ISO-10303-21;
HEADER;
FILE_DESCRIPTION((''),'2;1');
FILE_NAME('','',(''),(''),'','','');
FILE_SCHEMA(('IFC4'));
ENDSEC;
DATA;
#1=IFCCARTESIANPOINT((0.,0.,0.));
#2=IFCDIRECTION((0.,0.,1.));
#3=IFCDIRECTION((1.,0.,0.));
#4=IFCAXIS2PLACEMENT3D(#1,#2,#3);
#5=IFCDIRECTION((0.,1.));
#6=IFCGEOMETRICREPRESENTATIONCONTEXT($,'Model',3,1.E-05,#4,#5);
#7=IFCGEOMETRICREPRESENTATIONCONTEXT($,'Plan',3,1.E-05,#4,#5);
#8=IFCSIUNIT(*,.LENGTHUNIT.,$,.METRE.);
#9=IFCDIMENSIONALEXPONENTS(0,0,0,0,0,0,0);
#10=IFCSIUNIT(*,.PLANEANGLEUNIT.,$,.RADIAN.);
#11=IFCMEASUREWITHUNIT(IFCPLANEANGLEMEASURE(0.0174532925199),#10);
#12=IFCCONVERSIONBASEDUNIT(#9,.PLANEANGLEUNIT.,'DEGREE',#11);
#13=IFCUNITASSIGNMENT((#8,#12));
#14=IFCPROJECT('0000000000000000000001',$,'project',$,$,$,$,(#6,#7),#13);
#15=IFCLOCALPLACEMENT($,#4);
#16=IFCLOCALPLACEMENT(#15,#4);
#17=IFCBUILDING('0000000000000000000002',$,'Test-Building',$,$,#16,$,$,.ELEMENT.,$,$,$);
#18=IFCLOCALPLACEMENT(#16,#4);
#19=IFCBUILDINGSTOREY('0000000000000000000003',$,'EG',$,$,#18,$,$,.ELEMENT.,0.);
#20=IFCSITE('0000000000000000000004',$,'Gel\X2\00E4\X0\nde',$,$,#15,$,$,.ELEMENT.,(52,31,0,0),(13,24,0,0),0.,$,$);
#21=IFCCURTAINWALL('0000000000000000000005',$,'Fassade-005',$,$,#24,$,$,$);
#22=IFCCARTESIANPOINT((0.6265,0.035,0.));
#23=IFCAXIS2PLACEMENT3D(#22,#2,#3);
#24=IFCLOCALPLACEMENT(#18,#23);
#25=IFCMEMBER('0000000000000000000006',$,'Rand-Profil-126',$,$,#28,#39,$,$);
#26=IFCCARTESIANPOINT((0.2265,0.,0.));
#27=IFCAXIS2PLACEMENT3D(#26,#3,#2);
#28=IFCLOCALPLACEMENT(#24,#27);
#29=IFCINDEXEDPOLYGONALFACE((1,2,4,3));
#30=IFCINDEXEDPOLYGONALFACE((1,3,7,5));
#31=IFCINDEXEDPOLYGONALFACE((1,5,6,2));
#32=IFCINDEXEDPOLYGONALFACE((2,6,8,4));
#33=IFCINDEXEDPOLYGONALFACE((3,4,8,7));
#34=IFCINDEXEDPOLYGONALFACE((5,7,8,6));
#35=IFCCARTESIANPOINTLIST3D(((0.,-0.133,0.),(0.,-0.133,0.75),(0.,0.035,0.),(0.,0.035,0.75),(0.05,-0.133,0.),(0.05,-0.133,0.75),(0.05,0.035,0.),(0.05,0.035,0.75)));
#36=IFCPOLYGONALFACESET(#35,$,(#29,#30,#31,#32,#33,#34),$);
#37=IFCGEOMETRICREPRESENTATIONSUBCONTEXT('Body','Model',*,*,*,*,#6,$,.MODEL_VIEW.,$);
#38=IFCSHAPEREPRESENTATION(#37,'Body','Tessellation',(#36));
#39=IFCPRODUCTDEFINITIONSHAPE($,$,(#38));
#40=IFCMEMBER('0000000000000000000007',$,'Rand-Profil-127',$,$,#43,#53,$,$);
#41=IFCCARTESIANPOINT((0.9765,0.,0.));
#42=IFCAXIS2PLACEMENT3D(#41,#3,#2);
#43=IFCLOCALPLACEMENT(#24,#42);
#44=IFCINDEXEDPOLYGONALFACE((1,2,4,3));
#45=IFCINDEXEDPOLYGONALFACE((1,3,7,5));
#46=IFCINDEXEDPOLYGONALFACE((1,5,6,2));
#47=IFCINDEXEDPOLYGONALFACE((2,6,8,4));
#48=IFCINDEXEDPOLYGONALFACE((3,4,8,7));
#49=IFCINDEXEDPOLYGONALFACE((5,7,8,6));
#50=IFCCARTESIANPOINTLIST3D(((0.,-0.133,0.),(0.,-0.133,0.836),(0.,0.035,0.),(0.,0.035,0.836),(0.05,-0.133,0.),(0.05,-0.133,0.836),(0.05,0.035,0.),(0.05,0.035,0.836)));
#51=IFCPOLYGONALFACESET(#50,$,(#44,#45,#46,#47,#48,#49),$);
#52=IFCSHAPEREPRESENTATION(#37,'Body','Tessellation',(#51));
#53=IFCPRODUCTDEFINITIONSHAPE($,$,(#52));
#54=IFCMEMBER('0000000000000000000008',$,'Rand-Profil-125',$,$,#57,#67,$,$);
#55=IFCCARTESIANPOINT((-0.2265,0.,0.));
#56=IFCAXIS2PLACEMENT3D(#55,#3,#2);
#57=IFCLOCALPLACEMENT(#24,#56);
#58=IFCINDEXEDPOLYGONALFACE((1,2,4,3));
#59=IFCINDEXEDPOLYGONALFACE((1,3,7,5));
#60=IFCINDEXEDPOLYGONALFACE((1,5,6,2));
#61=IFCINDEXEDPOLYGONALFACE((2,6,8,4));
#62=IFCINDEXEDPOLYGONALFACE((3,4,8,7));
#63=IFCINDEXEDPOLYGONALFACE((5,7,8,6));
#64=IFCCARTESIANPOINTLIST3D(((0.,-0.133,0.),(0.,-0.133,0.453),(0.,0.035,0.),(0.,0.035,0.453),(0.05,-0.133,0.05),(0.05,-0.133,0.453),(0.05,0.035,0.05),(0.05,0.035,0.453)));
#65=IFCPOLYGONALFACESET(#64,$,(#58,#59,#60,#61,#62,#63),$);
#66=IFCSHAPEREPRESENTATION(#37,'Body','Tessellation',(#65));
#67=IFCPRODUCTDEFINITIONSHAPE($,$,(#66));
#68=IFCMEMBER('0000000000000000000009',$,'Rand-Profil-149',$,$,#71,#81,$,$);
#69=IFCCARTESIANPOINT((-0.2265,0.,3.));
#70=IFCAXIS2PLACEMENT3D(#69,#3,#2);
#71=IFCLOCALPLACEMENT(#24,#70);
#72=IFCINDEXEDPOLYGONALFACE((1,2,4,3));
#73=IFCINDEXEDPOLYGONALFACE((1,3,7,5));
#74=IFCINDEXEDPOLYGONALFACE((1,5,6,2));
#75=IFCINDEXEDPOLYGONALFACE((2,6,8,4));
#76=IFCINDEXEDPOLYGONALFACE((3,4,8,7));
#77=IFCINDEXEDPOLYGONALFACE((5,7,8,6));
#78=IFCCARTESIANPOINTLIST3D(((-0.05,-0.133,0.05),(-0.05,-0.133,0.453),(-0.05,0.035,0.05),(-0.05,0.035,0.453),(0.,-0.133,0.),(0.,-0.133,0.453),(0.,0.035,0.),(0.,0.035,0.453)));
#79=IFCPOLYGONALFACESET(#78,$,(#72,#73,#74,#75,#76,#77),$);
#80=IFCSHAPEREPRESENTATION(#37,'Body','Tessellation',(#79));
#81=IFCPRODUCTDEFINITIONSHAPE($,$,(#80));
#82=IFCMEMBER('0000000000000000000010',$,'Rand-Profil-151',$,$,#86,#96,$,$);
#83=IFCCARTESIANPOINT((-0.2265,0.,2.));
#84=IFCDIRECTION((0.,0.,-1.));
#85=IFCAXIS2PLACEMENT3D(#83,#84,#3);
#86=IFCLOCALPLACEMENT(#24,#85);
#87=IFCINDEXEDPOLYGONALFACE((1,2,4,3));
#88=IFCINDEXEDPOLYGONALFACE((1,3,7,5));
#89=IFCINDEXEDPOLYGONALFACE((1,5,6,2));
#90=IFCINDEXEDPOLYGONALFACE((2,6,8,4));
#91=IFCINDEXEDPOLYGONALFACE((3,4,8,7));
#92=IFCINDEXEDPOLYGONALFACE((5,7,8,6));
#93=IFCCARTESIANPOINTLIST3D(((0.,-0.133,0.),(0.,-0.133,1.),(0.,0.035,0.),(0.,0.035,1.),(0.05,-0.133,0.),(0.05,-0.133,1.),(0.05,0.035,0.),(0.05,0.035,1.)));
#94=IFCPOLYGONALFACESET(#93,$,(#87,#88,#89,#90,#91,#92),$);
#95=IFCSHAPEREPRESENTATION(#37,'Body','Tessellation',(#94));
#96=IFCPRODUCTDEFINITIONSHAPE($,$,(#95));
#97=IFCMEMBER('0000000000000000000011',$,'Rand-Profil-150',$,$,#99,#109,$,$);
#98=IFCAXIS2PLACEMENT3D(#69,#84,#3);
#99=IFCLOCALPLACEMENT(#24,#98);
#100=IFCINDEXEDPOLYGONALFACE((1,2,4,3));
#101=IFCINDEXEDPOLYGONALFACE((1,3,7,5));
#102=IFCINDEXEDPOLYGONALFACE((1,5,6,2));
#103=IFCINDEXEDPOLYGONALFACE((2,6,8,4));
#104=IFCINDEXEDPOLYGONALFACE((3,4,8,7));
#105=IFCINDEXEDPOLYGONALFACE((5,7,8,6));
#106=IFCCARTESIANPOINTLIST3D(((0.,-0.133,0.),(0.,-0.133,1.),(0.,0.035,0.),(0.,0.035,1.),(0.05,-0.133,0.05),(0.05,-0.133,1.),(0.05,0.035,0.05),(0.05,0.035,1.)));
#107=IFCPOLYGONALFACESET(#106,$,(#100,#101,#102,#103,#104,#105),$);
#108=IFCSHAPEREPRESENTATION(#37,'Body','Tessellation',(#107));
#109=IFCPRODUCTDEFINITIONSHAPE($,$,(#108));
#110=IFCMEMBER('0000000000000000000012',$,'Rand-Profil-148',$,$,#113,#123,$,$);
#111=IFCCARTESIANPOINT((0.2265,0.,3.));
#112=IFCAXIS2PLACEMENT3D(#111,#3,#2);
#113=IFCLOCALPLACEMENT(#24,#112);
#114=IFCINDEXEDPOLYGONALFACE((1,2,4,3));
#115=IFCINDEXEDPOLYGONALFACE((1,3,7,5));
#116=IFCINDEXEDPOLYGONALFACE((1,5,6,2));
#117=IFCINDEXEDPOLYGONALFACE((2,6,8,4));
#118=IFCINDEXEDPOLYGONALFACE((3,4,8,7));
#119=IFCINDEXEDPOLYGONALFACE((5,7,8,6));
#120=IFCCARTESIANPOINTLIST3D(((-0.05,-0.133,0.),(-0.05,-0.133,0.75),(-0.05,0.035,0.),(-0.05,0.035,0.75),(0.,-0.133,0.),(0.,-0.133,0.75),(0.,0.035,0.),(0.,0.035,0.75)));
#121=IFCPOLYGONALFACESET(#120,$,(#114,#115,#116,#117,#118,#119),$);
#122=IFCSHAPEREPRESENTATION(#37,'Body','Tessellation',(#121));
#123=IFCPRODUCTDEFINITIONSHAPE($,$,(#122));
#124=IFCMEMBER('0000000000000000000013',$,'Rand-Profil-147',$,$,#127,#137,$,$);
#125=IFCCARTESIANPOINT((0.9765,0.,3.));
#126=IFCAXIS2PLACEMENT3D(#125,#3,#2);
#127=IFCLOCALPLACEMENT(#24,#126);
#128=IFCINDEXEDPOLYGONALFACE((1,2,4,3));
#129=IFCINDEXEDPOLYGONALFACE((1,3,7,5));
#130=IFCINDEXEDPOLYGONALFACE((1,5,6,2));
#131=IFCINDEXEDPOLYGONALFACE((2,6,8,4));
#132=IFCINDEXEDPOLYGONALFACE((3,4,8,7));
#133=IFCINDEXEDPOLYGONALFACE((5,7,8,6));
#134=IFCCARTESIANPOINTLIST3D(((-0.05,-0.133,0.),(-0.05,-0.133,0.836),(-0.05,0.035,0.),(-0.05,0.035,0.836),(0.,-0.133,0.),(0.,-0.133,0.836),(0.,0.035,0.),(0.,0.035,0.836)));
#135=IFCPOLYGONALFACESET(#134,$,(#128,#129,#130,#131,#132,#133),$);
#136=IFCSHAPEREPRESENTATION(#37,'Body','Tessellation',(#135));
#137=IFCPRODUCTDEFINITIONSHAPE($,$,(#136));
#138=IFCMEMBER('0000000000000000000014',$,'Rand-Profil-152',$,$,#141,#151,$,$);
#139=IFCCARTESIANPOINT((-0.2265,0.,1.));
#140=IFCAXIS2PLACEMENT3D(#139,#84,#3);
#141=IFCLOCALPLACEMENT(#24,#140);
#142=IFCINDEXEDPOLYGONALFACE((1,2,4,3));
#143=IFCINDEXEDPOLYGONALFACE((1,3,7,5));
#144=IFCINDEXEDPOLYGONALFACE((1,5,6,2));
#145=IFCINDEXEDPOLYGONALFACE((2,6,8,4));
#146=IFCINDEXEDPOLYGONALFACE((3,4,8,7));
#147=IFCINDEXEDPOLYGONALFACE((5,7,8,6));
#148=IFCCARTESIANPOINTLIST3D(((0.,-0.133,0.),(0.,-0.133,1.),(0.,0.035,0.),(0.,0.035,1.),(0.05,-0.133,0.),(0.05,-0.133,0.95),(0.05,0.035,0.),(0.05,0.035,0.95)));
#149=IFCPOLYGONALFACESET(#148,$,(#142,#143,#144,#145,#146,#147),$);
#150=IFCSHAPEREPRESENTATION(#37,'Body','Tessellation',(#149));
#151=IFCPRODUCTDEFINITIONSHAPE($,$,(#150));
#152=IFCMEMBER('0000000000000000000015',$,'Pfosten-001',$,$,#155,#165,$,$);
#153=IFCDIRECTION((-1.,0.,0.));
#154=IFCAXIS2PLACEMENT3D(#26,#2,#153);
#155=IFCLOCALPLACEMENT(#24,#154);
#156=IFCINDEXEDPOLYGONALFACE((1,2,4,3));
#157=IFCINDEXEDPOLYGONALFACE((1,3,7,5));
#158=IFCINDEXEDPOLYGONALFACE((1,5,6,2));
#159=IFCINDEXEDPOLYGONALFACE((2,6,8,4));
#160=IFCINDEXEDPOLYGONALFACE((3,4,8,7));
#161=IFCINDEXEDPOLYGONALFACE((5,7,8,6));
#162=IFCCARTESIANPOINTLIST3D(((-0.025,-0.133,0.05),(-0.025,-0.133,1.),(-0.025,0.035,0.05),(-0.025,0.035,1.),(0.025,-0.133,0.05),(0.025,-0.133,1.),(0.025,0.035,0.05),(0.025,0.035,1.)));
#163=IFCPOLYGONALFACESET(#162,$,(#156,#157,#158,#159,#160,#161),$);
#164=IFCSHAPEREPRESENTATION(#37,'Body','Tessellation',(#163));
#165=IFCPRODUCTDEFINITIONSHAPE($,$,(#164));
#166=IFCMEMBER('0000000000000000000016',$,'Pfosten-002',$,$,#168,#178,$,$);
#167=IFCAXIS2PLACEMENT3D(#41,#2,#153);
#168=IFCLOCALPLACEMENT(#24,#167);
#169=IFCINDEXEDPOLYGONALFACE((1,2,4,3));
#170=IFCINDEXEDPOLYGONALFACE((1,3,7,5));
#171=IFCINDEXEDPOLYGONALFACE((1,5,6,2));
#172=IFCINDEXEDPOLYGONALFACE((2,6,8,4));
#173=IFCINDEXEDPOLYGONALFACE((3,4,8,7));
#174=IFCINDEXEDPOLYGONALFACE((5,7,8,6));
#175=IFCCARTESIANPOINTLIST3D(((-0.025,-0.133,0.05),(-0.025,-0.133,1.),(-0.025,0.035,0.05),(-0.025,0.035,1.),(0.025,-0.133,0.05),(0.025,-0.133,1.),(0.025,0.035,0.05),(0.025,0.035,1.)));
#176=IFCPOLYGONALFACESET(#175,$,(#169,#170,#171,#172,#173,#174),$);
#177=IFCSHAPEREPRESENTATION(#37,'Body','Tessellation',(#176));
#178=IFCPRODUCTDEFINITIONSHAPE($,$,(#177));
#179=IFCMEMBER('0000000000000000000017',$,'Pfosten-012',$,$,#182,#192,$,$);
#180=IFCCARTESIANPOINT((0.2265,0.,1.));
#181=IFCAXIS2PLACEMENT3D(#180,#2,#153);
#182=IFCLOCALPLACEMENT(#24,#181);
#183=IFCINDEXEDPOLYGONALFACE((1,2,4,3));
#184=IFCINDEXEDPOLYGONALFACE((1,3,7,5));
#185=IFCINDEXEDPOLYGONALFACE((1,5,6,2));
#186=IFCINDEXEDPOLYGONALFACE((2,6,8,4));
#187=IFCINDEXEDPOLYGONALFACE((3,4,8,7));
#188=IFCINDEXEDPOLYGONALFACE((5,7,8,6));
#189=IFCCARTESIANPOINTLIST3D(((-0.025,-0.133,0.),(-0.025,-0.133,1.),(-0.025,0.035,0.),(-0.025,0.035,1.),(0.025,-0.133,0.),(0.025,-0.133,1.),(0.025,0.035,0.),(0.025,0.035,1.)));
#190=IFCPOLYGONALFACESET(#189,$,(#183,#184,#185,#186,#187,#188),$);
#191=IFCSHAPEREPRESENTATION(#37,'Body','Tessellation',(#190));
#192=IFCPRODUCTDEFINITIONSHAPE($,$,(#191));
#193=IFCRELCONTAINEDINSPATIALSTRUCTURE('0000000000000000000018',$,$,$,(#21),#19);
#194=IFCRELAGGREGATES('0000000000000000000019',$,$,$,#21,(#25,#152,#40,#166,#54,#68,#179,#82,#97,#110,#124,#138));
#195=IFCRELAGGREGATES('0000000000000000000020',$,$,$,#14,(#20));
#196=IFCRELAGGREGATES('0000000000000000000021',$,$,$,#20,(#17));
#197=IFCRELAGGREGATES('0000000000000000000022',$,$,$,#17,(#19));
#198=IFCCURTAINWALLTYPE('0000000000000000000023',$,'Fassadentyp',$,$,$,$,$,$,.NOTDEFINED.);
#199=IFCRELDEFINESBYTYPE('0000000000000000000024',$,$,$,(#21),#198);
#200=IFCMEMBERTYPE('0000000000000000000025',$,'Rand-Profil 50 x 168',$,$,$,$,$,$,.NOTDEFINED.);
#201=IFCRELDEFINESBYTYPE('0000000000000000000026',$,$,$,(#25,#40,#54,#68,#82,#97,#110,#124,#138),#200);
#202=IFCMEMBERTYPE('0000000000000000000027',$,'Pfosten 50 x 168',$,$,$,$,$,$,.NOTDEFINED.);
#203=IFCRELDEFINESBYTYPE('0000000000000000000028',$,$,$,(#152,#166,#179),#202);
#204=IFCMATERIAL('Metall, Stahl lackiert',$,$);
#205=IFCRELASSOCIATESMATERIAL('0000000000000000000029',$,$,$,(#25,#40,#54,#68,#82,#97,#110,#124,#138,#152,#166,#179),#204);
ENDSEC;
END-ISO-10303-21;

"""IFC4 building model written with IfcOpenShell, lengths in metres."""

from ifc_helpers import new_model, entity, si_unit, converted_unit, direction, frame, origin_with_axes, place, context, subcontext, project, spatial, polyline, outline, extrude, clip, halfspace, material, type_object, element, aggregate, save


model = new_model("IFC4")

# Units and contexts
model_context = context("Model", 3, precision=1e-05, world=origin_with_axes(), true_north=direction((0.0, 1.0)))
plan_context = context("Plan", 3, precision=1e-05, world=origin_with_axes(), true_north=direction((0.0, 1.0)))
body_context = subcontext(model_context, "Body", "Model", "MODEL_VIEW")
ifc_project = project(units=[si_unit("LENGTHUNIT", "METRE"), converted_unit("PLANEANGLEUNIT", "DEGREE", entity("IfcPlaneAngleMeasure", 0.0174532925199), si_unit("PLANEANGLEUNIT", "RADIAN"), dimensions=[0, 0, 0, 0, 0, 0, 0])], contexts=[model_context, plan_context])

# Site, building, storey
site_placement = place(None, origin_with_axes())
site = spatial("IfcSite", under=ifc_project, at=site_placement, Name="Gelände", CompositionType="ELEMENT", RefLatitude=(52, 31, 0, 0), RefLongitude=(13, 24, 0, 0), RefElevation=0.0)
building_placement = place(site_placement, origin_with_axes())
building = spatial("IfcBuilding", under=site, at=building_placement, Name="Test-Building", CompositionType="ELEMENT")
storey_placement = place(building_placement, origin_with_axes())
storey = spatial("IfcBuildingStorey", under=building, at=storey_placement, Name="EG", CompositionType="ELEMENT", Elevation=0.0)

# Curtain wall, members
curtain_wall_type = type_object("IfcCurtainWallType", Name="Fassadentyp", PredefinedType="NOTDEFINED")
curtain_wall_placement = place(storey_placement, frame((0.6265, 0.035, 0.0), z_axis=(0.0, 0.0, 1.0), x_axis=(1.0, 0.0, 0.0)))
curtain_wall = element("IfcCurtainWall", 1, at=curtain_wall_placement, inside=storey, type_object=curtain_wall_type, Name="Fassade-005")
ifc_material_1 = material(Name="Metall, Stahl lackiert")
member_type_1 = type_object("IfcMemberType", Name="Rand-Profil 50 x 168", PredefinedType="NOTDEFINED")
member_1_placement = place(curtain_wall_placement, frame((0.2265, 0.0, 0.0), z_axis=(1.0, 0.0, 0.0), x_axis=(0.0, 0.0, 1.0)))
member_1 = element("IfcMember", 2, at=member_1_placement, type_object=member_type_1, material=ifc_material_1, Name="Rand-Profil-126", context=body_context, shape_type="SweptSolid", body=[
    extrude(outline(polyline([(-0.133, -0.05), (0.035, -0.05), (0.035, 0.0), (-0.133, 0.0), (-0.133, -0.05)])), frame((0.0, 0.0, 0.0), z_axis=(0.0, 0.0, 1.0), x_axis=(0.0, 1.0, 0.0)), (0.0, 0.0, 1.0), 0.75),
])
member_2_placement = place(curtain_wall_placement, frame((0.9765, 0.0, 0.0), z_axis=(1.0, 0.0, 0.0), x_axis=(0.0, 0.0, 1.0)))
member_2 = element("IfcMember", 3, at=member_2_placement, type_object=member_type_1, material=ifc_material_1, Name="Rand-Profil-127", context=body_context, shape_type="SweptSolid", body=[
    extrude(outline(polyline([(-0.133, -0.05), (0.035, -0.05), (0.035, 0.0), (-0.133, 0.0), (-0.133, -0.05)])), frame((0.0, 0.0, 0.0), z_axis=(0.0, 0.0, 1.0), x_axis=(0.0, 1.0, 0.0)), (0.0, 0.0, 1.0), 0.836),
])
member_3_placement = place(curtain_wall_placement, frame((-0.2265, 0.0, 0.0), z_axis=(1.0, 0.0, 0.0), x_axis=(0.0, 0.0, 1.0)))
member_3 = element("IfcMember", 4, at=member_3_placement, type_object=member_type_1, material=ifc_material_1, Name="Rand-Profil-125", context=body_context, shape_type="Clipping", body=[
    clip(extrude(outline(polyline([(-0.133, -0.05), (0.035, -0.05), (0.035, 0.0), (-0.133, 0.0), (-0.133, -0.05)])), frame((0.0, 0.0, 0.0), z_axis=(0.0, 0.0, 1.0), x_axis=(0.0, 1.0, 0.0)), (0.0, 0.0, 1.0), 0.453), halfspace(frame((0.0, 0.0, 0.0), z_axis=(-0.707107, 0.0, 0.707107), x_axis=(0.0, -1.0, 0.0)), True)),
])
member_4_placement = place(curtain_wall_placement, frame((-0.2265, 0.0, 3.0), z_axis=(1.0, 0.0, 0.0), x_axis=(0.0, 0.0, 1.0)))
member_4 = element("IfcMember", 5, at=member_4_placement, type_object=member_type_1, material=ifc_material_1, Name="Rand-Profil-149", context=body_context, shape_type="Clipping", body=[
    clip(extrude(outline(polyline([(-0.133, 0.05), (-0.133, 0.0), (0.035, 0.0), (0.035, 0.05), (-0.133, 0.05)])), frame((0.0, 0.0, 0.0), z_axis=(0.0, 0.0, 1.0), x_axis=(0.0, 1.0, 0.0)), (0.0, 0.0, 1.0), 0.453), halfspace(frame((0.0, 0.0, 0.0), z_axis=(0.707107, 0.0, 0.707107), x_axis=(0.0, -1.0, 0.0)), True)),
])
member_5_placement = place(curtain_wall_placement, frame((-0.2265, 0.0, 2.0), z_axis=(0.0, 0.0, -1.0), x_axis=(1.0, 0.0, 0.0)))
member_5 = element("IfcMember", 6, at=member_5_placement, type_object=member_type_1, material=ifc_material_1, Name="Rand-Profil-151", context=body_context, shape_type="SweptSolid", body=[
    extrude(outline(polyline([(0.05, -0.133), (0.05, 0.035), (0.0, 0.035), (0.0, -0.133), (0.05, -0.133)])), origin_with_axes(), (0.0, 0.0, 1.0), 1.0),
])
member_6_placement = place(curtain_wall_placement, frame((-0.2265, 0.0, 3.0), z_axis=(0.0, 0.0, -1.0), x_axis=(1.0, 0.0, 0.0)))
member_6 = element("IfcMember", 7, at=member_6_placement, type_object=member_type_1, material=ifc_material_1, Name="Rand-Profil-150", context=body_context, shape_type="Clipping", body=[
    clip(extrude(outline(polyline([(0.05, -0.133), (0.05, 0.035), (0.0, 0.035), (0.0, -0.133), (0.05, -0.133)])), origin_with_axes(), (0.0, 0.0, 1.0), 1.0), halfspace(frame((0.0, 0.0, 0.0), z_axis=(-0.707107, 0.0, 0.707107), x_axis=(0.0, -1.0, 0.0)), True)),
])
member_7_placement = place(curtain_wall_placement, frame((0.2265, 0.0, 3.0), z_axis=(1.0, 0.0, 0.0), x_axis=(0.0, 0.0, 1.0)))
member_7 = element("IfcMember", 8, at=member_7_placement, type_object=member_type_1, material=ifc_material_1, Name="Rand-Profil-148", context=body_context, shape_type="SweptSolid", body=[
    extrude(outline(polyline([(-0.133, 0.05), (-0.133, 0.0), (0.035, 0.0), (0.035, 0.05), (-0.133, 0.05)])), frame((0.0, 0.0, 0.0), z_axis=(0.0, 0.0, 1.0), x_axis=(0.0, 1.0, 0.0)), (0.0, 0.0, 1.0), 0.75),
])
member_8_placement = place(curtain_wall_placement, frame((0.9765, 0.0, 3.0), z_axis=(1.0, 0.0, 0.0), x_axis=(0.0, 0.0, 1.0)))
member_8 = element("IfcMember", 9, at=member_8_placement, type_object=member_type_1, material=ifc_material_1, Name="Rand-Profil-147", context=body_context, shape_type="SweptSolid", body=[
    extrude(outline(polyline([(-0.133, 0.05), (-0.133, 0.0), (0.035, 0.0), (0.035, 0.05), (-0.133, 0.05)])), frame((0.0, 0.0, 0.0), z_axis=(0.0, 0.0, 1.0), x_axis=(0.0, 1.0, 0.0)), (0.0, 0.0, 1.0), 0.836),
])
member_9_placement = place(curtain_wall_placement, frame((-0.2265, 0.0, 1.0), z_axis=(0.0, 0.0, -1.0), x_axis=(1.0, 0.0, 0.0)))
member_9 = element("IfcMember", 10, at=member_9_placement, type_object=member_type_1, material=ifc_material_1, Name="Rand-Profil-152", context=body_context, shape_type="Clipping", body=[
    clip(extrude(outline(polyline([(0.05, -0.133), (0.05, 0.035), (0.0, 0.035), (0.0, -0.133), (0.05, -0.133)])), origin_with_axes(), (0.0, 0.0, 1.0), 1.0), halfspace(frame((0.5, 0.0, 0.5), z_axis=(-0.707107, 0.0, -0.707107), x_axis=(0.0, 1.0, 0.0)), True)),
])
member_type_2 = type_object("IfcMemberType", Name="Pfosten 50 x 168", PredefinedType="NOTDEFINED")
member_10_placement = place(curtain_wall_placement, frame((0.2265, 0.0, 0.0), z_axis=(0.0, 0.0, 1.0), x_axis=(-1.0, 0.0, 0.0)))
member_10 = element("IfcMember", 11, at=member_10_placement, type_object=member_type_2, material=ifc_material_1, Name="Pfosten-001", context=body_context, shape_type="SweptSolid", body=[
    extrude(outline(polyline([(-0.025, 0.133), (-0.025, -0.035), (0.025, -0.035), (0.025, 0.133), (-0.025, 0.133)])), frame((0.0, 0.0, 0.05), z_axis=(0.0, 0.0, 1.0), x_axis=(-1.0, 0.0, 0.0)), (0.0, 0.0, 1.0), 0.95),
])
member_11_placement = place(curtain_wall_placement, frame((0.9765, 0.0, 0.0), z_axis=(0.0, 0.0, 1.0), x_axis=(-1.0, 0.0, 0.0)))
member_11 = element("IfcMember", 12, at=member_11_placement, type_object=member_type_2, material=ifc_material_1, Name="Pfosten-002", context=body_context, shape_type="SweptSolid", body=[
    extrude(outline(polyline([(-0.025, 0.133), (-0.025, -0.035), (0.025, -0.035), (0.025, 0.133), (-0.025, 0.133)])), frame((0.0, 0.0, 0.05), z_axis=(0.0, 0.0, 1.0), x_axis=(-1.0, 0.0, 0.0)), (0.0, 0.0, 1.0), 0.95),
])
member_12_placement = place(curtain_wall_placement, frame((0.2265, 0.0, 1.0), z_axis=(0.0, 0.0, 1.0), x_axis=(-1.0, 0.0, 0.0)))
member_12 = element("IfcMember", 13, at=member_12_placement, type_object=member_type_2, material=ifc_material_1, Name="Pfosten-012", context=body_context, shape_type="SweptSolid", body=[
    extrude(outline(polyline([(-0.025, 0.133), (-0.025, -0.035), (0.025, -0.035), (0.025, 0.133), (-0.025, 0.133)])), frame((0.0, 0.0, 0.0), z_axis=(0.0, 0.0, 1.0), x_axis=(-1.0, 0.0, 0.0)), (0.0, 0.0, 1.0), 1.0),
])
aggregate(curtain_wall, [member_1, member_10, member_2, member_11, member_3, member_4, member_12, member_5, member_6, member_7, member_8, member_9])

save(model, "model.ifc")
